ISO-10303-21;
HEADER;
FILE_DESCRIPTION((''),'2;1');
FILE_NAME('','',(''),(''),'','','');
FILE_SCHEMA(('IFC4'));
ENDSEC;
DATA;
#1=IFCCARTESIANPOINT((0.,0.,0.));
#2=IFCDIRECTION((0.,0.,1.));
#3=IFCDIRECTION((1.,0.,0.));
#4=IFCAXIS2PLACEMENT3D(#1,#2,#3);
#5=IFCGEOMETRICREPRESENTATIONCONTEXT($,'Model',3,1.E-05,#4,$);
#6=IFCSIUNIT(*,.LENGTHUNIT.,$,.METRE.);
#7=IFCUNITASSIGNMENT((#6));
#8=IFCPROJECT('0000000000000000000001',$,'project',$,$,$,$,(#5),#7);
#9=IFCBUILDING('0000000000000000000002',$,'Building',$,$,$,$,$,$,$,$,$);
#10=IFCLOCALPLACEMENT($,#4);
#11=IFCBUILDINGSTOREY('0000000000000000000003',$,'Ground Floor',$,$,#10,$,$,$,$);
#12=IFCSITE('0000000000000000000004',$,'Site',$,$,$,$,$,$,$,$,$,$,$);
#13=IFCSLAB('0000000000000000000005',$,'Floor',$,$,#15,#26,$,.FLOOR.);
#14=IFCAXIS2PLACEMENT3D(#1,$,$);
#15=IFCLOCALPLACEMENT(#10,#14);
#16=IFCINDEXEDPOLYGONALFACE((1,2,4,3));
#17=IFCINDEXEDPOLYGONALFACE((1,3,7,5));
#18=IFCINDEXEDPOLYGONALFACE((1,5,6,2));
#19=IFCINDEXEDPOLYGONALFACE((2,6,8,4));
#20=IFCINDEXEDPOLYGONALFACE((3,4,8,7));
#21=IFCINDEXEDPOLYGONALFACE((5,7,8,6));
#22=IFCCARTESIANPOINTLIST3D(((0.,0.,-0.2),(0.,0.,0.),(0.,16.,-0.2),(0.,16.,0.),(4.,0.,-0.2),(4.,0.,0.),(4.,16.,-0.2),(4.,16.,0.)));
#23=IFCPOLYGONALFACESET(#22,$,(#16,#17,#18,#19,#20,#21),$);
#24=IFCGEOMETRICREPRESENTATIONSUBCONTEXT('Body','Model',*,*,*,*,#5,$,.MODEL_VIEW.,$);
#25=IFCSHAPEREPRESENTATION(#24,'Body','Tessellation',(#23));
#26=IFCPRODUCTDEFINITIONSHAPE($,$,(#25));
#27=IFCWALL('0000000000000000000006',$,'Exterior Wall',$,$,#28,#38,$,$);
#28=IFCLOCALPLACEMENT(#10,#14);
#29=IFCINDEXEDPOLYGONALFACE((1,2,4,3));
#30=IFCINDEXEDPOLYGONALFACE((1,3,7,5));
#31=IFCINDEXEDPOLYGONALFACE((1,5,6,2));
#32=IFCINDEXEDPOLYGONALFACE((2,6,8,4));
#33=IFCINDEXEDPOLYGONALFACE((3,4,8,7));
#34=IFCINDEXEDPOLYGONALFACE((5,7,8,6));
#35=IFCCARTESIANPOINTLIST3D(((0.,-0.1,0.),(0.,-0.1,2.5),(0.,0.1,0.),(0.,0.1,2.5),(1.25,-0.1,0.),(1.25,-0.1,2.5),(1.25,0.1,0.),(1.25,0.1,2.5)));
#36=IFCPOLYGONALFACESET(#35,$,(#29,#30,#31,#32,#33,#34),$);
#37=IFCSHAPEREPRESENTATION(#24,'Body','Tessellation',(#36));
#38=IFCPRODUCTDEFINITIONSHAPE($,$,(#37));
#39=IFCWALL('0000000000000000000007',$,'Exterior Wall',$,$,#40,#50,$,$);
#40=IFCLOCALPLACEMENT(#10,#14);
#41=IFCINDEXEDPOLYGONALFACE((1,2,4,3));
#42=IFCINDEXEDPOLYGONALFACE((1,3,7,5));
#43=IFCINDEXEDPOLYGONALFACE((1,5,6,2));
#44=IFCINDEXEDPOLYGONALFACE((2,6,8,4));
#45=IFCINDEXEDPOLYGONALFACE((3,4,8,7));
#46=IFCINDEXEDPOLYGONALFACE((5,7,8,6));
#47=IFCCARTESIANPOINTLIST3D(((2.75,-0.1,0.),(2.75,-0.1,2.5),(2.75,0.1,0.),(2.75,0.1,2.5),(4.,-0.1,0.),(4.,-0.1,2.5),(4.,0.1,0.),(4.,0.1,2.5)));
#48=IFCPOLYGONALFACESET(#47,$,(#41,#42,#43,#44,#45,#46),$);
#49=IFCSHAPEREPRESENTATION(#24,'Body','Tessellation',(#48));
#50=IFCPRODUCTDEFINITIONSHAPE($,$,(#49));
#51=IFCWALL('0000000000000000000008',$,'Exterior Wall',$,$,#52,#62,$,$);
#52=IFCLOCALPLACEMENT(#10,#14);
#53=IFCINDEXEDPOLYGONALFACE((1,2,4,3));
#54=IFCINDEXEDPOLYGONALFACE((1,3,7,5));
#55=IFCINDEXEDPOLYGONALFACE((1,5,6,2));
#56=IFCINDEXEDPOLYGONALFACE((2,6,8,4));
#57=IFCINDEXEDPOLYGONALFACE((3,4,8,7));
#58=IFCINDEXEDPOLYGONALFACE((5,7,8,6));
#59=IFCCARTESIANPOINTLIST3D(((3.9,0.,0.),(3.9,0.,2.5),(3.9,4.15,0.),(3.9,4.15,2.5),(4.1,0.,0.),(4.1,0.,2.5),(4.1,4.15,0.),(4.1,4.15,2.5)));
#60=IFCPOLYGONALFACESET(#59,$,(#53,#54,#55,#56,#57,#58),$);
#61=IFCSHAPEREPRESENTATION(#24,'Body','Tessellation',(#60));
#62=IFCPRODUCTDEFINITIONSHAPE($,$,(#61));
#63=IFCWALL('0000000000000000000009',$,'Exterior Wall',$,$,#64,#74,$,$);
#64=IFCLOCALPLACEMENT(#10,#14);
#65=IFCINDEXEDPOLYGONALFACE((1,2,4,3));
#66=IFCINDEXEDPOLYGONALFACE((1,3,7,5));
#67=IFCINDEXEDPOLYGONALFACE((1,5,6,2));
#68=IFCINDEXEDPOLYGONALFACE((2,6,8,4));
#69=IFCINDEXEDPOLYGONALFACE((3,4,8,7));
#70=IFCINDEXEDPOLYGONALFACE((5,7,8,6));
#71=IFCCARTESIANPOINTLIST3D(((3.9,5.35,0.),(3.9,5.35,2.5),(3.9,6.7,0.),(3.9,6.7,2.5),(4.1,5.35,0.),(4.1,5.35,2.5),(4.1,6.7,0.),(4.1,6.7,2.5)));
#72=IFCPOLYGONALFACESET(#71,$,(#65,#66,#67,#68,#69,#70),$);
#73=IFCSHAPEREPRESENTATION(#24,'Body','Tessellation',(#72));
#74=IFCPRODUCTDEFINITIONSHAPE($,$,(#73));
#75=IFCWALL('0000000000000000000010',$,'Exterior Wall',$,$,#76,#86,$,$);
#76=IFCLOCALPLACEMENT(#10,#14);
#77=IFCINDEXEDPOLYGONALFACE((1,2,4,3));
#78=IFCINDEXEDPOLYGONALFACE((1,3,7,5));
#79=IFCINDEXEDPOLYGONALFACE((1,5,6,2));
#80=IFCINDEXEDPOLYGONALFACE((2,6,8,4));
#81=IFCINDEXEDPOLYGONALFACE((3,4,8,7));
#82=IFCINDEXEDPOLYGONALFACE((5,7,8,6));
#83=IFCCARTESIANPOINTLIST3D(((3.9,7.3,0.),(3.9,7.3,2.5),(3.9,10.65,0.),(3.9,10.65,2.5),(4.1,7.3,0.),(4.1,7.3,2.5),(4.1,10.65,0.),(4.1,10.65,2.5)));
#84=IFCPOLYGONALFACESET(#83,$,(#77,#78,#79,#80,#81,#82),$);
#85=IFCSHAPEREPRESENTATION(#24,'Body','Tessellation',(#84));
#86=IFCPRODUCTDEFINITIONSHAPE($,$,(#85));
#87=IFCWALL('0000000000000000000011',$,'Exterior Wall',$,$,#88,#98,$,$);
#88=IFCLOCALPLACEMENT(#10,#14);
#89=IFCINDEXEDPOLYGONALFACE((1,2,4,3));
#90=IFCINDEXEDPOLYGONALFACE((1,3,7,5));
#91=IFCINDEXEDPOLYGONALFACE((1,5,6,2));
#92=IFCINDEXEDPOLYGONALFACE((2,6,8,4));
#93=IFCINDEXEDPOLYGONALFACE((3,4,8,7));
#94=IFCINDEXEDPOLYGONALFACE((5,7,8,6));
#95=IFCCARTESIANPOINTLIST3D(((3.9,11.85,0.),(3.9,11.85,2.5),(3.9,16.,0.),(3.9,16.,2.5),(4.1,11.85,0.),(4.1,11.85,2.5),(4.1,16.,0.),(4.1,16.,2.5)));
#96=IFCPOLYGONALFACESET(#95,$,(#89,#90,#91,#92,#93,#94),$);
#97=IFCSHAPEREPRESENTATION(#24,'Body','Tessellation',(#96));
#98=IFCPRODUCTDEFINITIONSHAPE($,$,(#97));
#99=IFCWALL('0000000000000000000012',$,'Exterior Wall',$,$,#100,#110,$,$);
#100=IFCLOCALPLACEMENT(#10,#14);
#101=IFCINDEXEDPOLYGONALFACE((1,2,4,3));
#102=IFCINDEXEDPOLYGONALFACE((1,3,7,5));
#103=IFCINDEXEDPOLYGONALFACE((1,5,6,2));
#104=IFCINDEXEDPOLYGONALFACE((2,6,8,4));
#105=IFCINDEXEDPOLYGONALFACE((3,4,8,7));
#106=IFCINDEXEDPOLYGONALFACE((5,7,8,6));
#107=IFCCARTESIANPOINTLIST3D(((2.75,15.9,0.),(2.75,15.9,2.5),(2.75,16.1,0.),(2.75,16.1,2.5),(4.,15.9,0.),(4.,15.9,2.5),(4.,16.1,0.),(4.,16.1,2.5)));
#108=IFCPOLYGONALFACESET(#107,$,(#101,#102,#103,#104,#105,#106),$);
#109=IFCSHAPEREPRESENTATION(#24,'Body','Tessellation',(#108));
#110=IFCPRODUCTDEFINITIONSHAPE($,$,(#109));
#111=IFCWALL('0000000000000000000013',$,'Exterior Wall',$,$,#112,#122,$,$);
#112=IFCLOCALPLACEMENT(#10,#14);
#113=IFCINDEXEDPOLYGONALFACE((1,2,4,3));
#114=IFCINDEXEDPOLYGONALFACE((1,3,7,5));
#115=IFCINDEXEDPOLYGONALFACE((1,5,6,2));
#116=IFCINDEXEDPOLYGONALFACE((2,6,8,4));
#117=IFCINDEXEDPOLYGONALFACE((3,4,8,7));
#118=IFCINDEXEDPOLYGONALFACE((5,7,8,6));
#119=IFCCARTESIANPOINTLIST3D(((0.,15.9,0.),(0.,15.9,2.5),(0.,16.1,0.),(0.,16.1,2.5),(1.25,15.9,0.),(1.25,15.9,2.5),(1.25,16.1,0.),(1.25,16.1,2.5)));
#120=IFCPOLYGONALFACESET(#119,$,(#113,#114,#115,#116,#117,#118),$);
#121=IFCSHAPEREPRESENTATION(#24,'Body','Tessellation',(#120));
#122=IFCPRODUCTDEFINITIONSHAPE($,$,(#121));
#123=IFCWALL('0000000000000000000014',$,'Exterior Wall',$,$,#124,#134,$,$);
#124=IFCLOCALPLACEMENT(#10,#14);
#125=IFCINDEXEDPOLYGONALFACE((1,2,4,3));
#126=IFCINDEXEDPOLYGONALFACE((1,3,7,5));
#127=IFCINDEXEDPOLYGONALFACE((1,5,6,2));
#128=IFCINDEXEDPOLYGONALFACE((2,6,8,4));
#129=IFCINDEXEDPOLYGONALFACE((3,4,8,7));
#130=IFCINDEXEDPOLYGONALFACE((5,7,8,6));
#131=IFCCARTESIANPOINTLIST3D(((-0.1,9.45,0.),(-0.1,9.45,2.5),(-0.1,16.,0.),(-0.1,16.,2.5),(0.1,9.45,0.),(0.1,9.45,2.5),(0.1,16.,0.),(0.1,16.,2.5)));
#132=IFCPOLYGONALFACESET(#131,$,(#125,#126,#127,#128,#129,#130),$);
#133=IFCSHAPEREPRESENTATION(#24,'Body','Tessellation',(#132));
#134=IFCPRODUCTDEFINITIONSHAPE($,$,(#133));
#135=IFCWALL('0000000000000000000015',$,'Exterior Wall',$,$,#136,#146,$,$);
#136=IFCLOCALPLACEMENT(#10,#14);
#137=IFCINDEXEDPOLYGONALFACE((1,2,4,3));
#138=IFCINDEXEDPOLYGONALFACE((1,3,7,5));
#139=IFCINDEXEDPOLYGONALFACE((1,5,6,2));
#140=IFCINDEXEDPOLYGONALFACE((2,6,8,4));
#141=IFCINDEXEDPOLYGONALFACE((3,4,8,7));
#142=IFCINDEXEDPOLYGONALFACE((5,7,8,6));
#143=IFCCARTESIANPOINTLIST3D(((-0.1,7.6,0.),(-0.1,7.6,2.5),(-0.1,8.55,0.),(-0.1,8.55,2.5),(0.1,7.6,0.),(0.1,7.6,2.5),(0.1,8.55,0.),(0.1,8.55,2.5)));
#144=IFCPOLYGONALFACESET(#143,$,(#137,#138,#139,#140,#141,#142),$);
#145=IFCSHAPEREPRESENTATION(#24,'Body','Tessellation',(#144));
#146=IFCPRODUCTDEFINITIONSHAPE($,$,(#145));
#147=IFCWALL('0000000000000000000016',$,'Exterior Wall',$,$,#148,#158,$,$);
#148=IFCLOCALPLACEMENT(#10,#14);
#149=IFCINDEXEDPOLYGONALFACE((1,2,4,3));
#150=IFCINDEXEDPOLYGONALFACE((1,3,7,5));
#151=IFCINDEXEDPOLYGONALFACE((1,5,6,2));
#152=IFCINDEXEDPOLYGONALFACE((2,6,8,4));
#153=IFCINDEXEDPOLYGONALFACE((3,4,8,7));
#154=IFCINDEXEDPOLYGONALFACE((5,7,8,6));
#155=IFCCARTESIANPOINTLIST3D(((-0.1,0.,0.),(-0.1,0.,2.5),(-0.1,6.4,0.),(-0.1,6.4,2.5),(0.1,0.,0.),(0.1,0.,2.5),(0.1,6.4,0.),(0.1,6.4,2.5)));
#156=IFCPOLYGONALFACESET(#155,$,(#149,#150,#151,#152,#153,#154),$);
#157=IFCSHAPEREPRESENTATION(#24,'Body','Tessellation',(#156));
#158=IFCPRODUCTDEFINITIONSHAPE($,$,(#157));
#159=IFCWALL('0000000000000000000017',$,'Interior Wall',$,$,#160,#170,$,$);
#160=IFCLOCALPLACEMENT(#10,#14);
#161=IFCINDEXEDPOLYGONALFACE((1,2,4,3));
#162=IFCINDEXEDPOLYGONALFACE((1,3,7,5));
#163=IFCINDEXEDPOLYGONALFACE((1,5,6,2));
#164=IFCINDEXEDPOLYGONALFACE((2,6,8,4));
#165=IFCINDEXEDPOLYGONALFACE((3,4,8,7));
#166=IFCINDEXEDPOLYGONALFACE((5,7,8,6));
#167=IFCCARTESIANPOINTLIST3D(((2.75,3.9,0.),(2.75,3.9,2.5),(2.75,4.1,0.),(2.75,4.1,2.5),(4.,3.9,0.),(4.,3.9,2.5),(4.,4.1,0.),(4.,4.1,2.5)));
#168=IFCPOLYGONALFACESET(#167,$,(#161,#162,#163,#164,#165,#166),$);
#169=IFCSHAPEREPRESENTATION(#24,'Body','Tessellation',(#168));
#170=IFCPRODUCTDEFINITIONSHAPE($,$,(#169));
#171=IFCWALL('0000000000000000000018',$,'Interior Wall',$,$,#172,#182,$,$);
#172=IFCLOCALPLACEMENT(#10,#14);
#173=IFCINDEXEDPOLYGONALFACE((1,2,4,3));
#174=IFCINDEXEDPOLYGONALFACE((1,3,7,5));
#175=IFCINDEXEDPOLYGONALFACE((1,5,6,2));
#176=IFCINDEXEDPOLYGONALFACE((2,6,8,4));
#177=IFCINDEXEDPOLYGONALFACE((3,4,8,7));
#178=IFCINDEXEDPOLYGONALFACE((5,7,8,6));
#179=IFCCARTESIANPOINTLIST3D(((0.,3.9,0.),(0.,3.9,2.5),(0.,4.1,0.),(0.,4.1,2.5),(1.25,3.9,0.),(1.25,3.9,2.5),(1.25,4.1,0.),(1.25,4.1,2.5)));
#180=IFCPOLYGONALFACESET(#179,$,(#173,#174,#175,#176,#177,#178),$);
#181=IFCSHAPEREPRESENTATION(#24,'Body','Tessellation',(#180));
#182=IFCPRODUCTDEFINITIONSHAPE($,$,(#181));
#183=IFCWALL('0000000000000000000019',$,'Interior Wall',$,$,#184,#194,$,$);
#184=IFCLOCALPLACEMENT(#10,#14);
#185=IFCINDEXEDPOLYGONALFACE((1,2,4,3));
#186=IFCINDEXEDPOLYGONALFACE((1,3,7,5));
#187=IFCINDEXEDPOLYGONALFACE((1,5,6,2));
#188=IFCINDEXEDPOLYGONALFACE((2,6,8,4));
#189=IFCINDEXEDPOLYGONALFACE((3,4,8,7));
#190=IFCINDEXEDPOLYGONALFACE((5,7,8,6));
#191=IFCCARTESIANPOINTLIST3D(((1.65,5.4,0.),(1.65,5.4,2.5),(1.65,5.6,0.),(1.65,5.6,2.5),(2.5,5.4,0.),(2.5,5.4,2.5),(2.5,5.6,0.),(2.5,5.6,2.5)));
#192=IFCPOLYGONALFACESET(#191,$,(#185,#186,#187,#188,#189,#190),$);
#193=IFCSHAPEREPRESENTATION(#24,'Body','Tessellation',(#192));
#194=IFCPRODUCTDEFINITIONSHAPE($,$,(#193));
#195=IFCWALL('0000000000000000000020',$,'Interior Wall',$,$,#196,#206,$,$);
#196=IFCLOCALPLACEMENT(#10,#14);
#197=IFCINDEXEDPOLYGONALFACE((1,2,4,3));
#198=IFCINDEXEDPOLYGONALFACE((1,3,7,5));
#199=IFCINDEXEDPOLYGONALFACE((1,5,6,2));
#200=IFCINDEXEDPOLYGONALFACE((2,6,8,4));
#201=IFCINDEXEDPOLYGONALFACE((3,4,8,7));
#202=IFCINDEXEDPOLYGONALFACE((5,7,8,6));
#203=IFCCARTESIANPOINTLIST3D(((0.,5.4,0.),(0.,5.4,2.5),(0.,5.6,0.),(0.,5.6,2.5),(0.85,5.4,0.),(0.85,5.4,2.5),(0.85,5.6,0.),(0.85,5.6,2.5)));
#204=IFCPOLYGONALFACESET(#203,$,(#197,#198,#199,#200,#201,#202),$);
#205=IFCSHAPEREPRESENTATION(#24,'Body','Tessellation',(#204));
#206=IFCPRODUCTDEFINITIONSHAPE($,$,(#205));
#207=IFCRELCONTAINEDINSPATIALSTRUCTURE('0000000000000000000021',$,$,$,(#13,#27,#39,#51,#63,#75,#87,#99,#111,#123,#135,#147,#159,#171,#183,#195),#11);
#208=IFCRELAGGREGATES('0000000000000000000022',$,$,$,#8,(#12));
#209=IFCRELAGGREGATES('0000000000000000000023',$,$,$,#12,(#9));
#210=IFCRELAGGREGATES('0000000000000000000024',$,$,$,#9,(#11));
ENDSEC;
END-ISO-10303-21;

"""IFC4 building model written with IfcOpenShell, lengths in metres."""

from ifc_helpers import new_model, si_unit, frame, origin_with_axes, place, context, subcontext, project, spatial, indexed_curve, outline, extrude, element, save


model = new_model("IFC4")

# Units and contexts
model_context = context("Model", 3, precision=1e-05, world=origin_with_axes())
body_context = subcontext(model_context, "Body", "Model", "MODEL_VIEW")
ifc_project = project(units=[si_unit("LENGTHUNIT", "METRE")], contexts=[model_context])

# Site, building, storey
site = spatial("IfcSite", under=ifc_project, Name="Site")
building = spatial("IfcBuilding", under=site, Name="Building")
storey_placement = place(None, origin_with_axes())
storey = spatial("IfcBuildingStorey", under=building, at=storey_placement, Name="Ground Floor")

# Slab
slab_placement = place(storey_placement, frame((0.0, 0.0, -0.2), z_axis=(0.0, 0.0, 1.0), x_axis=(1.0, 0.0, 0.0)))
element("IfcSlab", 1, at=slab_placement, inside=storey, Name="Floor", PredefinedType="FLOOR", context=body_context, shape_type="SweptSolid", body=[
    extrude(outline(indexed_curve([(0.0, 0.0), (4.0, 0.0), (4.0, 16.0), (0.0, 16.0)])), None, (0.0, 0.0, 1.0), 0.2),
])

# Walls
for number, where, z_axis, x_axis, name in (
    (2, (0.0, 0.0, 0.0), (0.0, 0.0, 1.0), (1.0, 0.0, 0.0), "Exterior Wall"),
    (3, (2.75, 0.0, 0.0), (0.0, 0.0, 1.0), (1.0, 0.0, 0.0), "Exterior Wall"),
):
    element("IfcWall", number, at=place(storey_placement, frame(where, z_axis=z_axis, x_axis=x_axis)), inside=storey, Name=name, context=body_context, shape_type="SweptSolid", body=[
        extrude(outline(indexed_curve([(0.0, 0.0), (0.0, 0.2), (1.25, 0.2), (1.25, 0.0), (0.0, 0.0)], self_intersect=False)), frame((0.0, -0.1, 0.0), z_axis=(0.0, 0.0, 1.0), x_axis=(1.0, 0.0, 0.0)), (0.0, 0.0, 1.0), 2.5),
    ])
wall_1_placement = place(storey_placement, frame((4.0, 0.0, 0.0), z_axis=(0.0, 0.0, 1.0), x_axis=(0.0, 1.0, 0.0)))
element("IfcWall", 4, at=wall_1_placement, inside=storey, Name="Exterior Wall", context=body_context, shape_type="SweptSolid", body=[
    extrude(outline(indexed_curve([(0.0, 0.0), (0.0, 0.2), (4.15, 0.2), (4.15, 0.0), (0.0, 0.0)], self_intersect=False)), frame((0.0, -0.1, 0.0), z_axis=(0.0, 0.0, 1.0), x_axis=(1.0, 0.0, 0.0)), (0.0, 0.0, 1.0), 2.5),
])
wall_2_placement = place(storey_placement, frame((4.0, 5.35, 0.0), z_axis=(0.0, 0.0, 1.0), x_axis=(0.0, 1.0, 0.0)))
element("IfcWall", 5, at=wall_2_placement, inside=storey, Name="Exterior Wall", context=body_context, shape_type="SweptSolid", body=[
    extrude(outline(indexed_curve([(0.0, 0.0), (0.0, 0.2), (1.35, 0.2), (1.35, 0.0), (0.0, 0.0)], self_intersect=False)), frame((0.0, -0.1, 0.0), z_axis=(0.0, 0.0, 1.0), x_axis=(1.0, 0.0, 0.0)), (0.0, 0.0, 1.0), 2.5),
])
wall_3_placement = place(storey_placement, frame((4.0, 7.3, 0.0), z_axis=(0.0, 0.0, 1.0), x_axis=(0.0, 1.0, 0.0)))
element("IfcWall", 6, at=wall_3_placement, inside=storey, Name="Exterior Wall", context=body_context, shape_type="SweptSolid", body=[
    extrude(outline(indexed_curve([(0.0, 0.0), (0.0, 0.2), (3.35, 0.2), (3.35, 0.0), (0.0, 0.0)], self_intersect=False)), frame((0.0, -0.1, 0.0), z_axis=(0.0, 0.0, 1.0), x_axis=(1.0, 0.0, 0.0)), (0.0, 0.0, 1.0), 2.5),
])
wall_4_placement = place(storey_placement, frame((4.0, 11.85, 0.0), z_axis=(0.0, 0.0, 1.0), x_axis=(0.0, 1.0, 0.0)))
element("IfcWall", 7, at=wall_4_placement, inside=storey, Name="Exterior Wall", context=body_context, shape_type="SweptSolid", body=[
    extrude(outline(indexed_curve([(0.0, 0.0), (0.0, 0.2), (4.15, 0.2), (4.15, 0.0), (0.0, 0.0)], self_intersect=False)), frame((0.0, -0.1, 0.0), z_axis=(0.0, 0.0, 1.0), x_axis=(1.0, 0.0, 0.0)), (0.0, 0.0, 1.0), 2.5),
])
for number, where, z_axis, x_axis, name in (
    (8, (4.0, 16.0, 0.0), (0.0, 0.0, 1.0), (-1.0, 0.0, 0.0), "Exterior Wall"),
    (9, (1.25, 16.0, 0.0), (0.0, 0.0, 1.0), (-1.0, 0.0, 0.0), "Exterior Wall"),
):
    element("IfcWall", number, at=place(storey_placement, frame(where, z_axis=z_axis, x_axis=x_axis)), inside=storey, Name=name, context=body_context, shape_type="SweptSolid", body=[
        extrude(outline(indexed_curve([(0.0, 0.0), (0.0, 0.2), (1.25, 0.2), (1.25, 0.0), (0.0, 0.0)], self_intersect=False)), frame((0.0, -0.1, 0.0), z_axis=(0.0, 0.0, 1.0), x_axis=(1.0, 0.0, 0.0)), (0.0, 0.0, 1.0), 2.5),
    ])
wall_5_placement = place(storey_placement, frame((0.0, 16.0, 0.0), z_axis=(0.0, 0.0, 1.0), x_axis=(0.0, -1.0, 0.0)))
element("IfcWall", 10, at=wall_5_placement, inside=storey, Name="Exterior Wall", context=body_context, shape_type="SweptSolid", body=[
    extrude(outline(indexed_curve([(0.0, 0.0), (0.0, 0.2), (6.55, 0.2), (6.55, 0.0), (0.0, 0.0)], self_intersect=False)), frame((0.0, -0.1, 0.0), z_axis=(0.0, 0.0, 1.0), x_axis=(1.0, 0.0, 0.0)), (0.0, 0.0, 1.0), 2.5),
])
wall_6_placement = place(storey_placement, frame((0.0, 8.55, 0.0), z_axis=(0.0, 0.0, 1.0), x_axis=(0.0, -1.0, 0.0)))
element("IfcWall", 11, at=wall_6_placement, inside=storey, Name="Exterior Wall", context=body_context, shape_type="SweptSolid", body=[
    extrude(outline(indexed_curve([(0.0, 0.0), (0.0, 0.2), (0.95, 0.2), (0.95, 0.0), (0.0, 0.0)], self_intersect=False)), frame((0.0, -0.1, 0.0), z_axis=(0.0, 0.0, 1.0), x_axis=(1.0, 0.0, 0.0)), (0.0, 0.0, 1.0), 2.5),
])
wall_7_placement = place(storey_placement, frame((0.0, 6.4, 0.0), z_axis=(0.0, 0.0, 1.0), x_axis=(0.0, -1.0, 0.0)))
element("IfcWall", 12, at=wall_7_placement, inside=storey, Name="Exterior Wall", context=body_context, shape_type="SweptSolid", body=[
    extrude(outline(indexed_curve([(0.0, 0.0), (0.0, 0.2), (6.4, 0.2), (6.4, 0.0), (0.0, 0.0)], self_intersect=False)), frame((0.0, -0.1, 0.0), z_axis=(0.0, 0.0, 1.0), x_axis=(1.0, 0.0, 0.0)), (0.0, 0.0, 1.0), 2.5),
])
for number, where, z_axis, x_axis, name in (
    (13, (4.0, 4.0, 0.0), (0.0, 0.0, 1.0), (-1.0, 0.0, 0.0), "Interior Wall"),
    (14, (1.25, 4.0, 0.0), (0.0, 0.0, 1.0), (-1.0, 0.0, 0.0), "Interior Wall"),
):
    element("IfcWall", number, at=place(storey_placement, frame(where, z_axis=z_axis, x_axis=x_axis)), inside=storey, Name=name, context=body_context, shape_type="SweptSolid", body=[
        extrude(outline(indexed_curve([(0.0, 0.0), (0.0, 0.2), (1.25, 0.2), (1.25, 0.0), (0.0, 0.0)], self_intersect=False)), frame((0.0, -0.1, 0.0), z_axis=(0.0, 0.0, 1.0), x_axis=(1.0, 0.0, 0.0)), (0.0, 0.0, 1.0), 2.5),
    ])
for number, where, z_axis, x_axis, name in (
    (15, (2.5, 5.5, 0.0), (0.0, 0.0, 1.0), (-1.0, 0.0, 0.0), "Interior Wall"),
    (16, (0.85, 5.5, 0.0), (0.0, 0.0, 1.0), (-1.0, 0.0, 0.0), "Interior Wall"),
):
    element("IfcWall", number, at=place(storey_placement, frame(where, z_axis=z_axis, x_axis=x_axis)), inside=storey, Name=name, context=body_context, shape_type="SweptSolid", body=[
        extrude(outline(indexed_curve([(0.0, 0.0), (0.0, 0.2), (0.85, 0.2), (0.85, 0.0), (0.0, 0.0)], self_intersect=False)), frame((0.0, -0.1, 0.0), z_axis=(0.0, 0.0, 1.0), x_axis=(1.0, 0.0, 0.0)), (0.0, 0.0, 1.0), 2.5),
    ])

save(model, "model.ifc")
